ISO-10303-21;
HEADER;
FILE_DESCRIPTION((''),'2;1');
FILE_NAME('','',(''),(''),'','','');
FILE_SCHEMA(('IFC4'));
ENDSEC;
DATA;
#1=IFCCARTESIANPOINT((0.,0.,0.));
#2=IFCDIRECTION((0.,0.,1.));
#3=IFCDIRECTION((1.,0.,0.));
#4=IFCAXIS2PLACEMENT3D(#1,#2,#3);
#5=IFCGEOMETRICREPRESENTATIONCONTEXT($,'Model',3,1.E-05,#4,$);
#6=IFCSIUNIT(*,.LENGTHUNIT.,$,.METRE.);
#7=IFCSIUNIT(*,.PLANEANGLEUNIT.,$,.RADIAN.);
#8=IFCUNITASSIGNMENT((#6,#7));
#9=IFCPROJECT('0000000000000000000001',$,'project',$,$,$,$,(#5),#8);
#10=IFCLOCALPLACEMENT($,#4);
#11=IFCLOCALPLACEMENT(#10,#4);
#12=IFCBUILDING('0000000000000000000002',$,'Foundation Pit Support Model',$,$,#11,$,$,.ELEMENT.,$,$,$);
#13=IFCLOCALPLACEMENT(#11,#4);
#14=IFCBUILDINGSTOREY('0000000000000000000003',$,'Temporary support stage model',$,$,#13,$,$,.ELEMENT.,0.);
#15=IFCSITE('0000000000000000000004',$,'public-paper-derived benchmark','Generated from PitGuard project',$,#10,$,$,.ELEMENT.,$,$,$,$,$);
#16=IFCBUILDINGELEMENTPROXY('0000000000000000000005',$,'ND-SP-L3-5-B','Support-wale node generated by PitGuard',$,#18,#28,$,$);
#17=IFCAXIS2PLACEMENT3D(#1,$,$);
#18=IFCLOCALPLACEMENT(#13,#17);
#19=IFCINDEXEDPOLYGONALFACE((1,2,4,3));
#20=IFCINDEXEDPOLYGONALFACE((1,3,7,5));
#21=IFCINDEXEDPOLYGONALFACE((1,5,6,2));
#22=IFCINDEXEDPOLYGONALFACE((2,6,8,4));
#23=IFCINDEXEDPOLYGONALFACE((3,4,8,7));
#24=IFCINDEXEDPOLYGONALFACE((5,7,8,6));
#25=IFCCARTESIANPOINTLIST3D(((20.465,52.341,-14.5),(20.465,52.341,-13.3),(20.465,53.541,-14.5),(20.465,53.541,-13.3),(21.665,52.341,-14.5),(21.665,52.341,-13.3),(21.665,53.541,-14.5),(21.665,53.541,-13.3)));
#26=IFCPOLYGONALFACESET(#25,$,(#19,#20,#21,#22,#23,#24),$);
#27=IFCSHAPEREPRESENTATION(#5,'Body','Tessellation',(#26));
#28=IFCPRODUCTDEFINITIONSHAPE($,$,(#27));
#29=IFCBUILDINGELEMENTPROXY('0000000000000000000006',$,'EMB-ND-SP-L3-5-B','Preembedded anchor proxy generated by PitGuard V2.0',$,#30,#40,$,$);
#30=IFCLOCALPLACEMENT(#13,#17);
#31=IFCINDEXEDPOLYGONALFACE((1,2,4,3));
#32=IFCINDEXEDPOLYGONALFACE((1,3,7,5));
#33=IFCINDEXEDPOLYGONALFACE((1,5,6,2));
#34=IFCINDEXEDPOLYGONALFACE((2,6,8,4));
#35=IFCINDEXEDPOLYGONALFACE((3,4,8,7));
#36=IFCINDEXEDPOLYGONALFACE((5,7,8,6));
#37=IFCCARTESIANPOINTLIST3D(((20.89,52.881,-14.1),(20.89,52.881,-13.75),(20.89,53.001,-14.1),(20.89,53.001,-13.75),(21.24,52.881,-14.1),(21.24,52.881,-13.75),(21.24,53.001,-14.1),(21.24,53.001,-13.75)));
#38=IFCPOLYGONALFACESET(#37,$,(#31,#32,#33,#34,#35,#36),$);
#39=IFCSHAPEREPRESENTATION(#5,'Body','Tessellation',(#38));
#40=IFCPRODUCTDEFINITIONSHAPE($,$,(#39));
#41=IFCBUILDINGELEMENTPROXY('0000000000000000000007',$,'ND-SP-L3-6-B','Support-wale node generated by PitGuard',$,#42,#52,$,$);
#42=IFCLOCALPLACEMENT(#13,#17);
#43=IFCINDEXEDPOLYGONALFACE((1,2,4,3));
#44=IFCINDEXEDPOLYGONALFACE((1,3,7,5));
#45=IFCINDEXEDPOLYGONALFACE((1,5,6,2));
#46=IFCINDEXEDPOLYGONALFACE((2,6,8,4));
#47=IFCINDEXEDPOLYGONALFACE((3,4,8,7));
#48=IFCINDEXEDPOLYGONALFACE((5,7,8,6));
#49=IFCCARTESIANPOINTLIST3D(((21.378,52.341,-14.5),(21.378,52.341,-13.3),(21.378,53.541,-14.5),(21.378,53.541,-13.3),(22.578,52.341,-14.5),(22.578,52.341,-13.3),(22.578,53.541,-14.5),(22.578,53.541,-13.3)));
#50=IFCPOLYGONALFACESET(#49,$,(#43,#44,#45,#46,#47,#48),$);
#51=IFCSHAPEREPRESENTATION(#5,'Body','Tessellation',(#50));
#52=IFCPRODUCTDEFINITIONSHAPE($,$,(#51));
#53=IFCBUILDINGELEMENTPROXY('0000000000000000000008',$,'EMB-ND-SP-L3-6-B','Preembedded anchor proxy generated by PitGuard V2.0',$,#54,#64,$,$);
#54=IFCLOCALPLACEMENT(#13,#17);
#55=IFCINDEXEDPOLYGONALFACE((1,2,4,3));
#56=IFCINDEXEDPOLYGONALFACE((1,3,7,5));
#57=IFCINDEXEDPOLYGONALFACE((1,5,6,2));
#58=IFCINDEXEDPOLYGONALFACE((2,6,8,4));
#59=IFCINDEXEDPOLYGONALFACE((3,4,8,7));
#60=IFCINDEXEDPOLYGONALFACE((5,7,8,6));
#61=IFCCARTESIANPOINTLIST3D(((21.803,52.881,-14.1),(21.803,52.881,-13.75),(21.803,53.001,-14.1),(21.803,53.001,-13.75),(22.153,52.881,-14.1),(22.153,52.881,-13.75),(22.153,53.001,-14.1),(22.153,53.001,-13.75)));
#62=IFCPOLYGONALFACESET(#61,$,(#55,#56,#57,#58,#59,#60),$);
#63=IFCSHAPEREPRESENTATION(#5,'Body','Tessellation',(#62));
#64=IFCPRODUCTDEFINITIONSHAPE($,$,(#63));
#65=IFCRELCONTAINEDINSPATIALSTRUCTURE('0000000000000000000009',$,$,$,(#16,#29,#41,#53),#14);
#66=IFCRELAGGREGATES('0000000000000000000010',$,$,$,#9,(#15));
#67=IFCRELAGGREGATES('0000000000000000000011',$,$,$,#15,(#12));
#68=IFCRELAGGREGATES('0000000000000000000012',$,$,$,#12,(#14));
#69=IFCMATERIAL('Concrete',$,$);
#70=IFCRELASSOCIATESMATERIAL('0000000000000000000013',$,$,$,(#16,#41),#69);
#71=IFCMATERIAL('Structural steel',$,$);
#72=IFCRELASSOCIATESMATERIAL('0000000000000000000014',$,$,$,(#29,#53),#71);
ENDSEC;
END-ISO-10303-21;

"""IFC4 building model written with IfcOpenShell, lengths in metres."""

from ifc_helpers import new_model, si_unit, frame, origin_with_axes, origin_2d, place, context, project, spatial, rectangle, extrude, material, element, save


model = new_model("IFC4")

# Units and contexts
model_context = context("Model", 3, precision=1e-05, world=origin_with_axes())
ifc_project = project(units=[si_unit("LENGTHUNIT", "METRE"), si_unit("PLANEANGLEUNIT", "RADIAN")], contexts=[model_context])

# Site, building, storey
site_placement = place(None, origin_with_axes())
site = spatial("IfcSite", under=ifc_project, at=site_placement, Name="public-paper-derived benchmark", Description="Generated from PitGuard project", CompositionType="ELEMENT")
building_placement = place(site_placement, origin_with_axes())
building = spatial("IfcBuilding", under=site, at=building_placement, Name="Foundation Pit Support Model", CompositionType="ELEMENT")
storey_placement = place(building_placement, origin_with_axes())
storey = spatial("IfcBuildingStorey", under=building, at=storey_placement, Name="Temporary support stage model", CompositionType="ELEMENT", Elevation=0.0)

# Shared definitions
ifc_material_1 = material(Name="Structural steel")

# Building element proxies
ifc_material_2 = material(Name="Concrete")
proxy_1_placement = place(storey_placement, frame((21.065, 52.941, -14.5), z_axis=(0.0, 0.0, 1.0), x_axis=(1.0, 0.0, 0.0)))
element("IfcBuildingElementProxy", 1, at=proxy_1_placement, inside=storey, material=ifc_material_2, Name="ND-SP-L3-5-B", Description="Support-wale node generated by PitGuard", context=model_context, shape_type="SweptSolid", body=[
    extrude(rectangle(XDim=1.2, YDim=1.2, at=origin_2d()), origin_with_axes(), (0.0, 0.0, 1.0), 1.2),
])
proxy_2_placement = place(storey_placement, frame((21.065, 52.941, -14.1), z_axis=(0.0, 0.0, 1.0), x_axis=(1.0, 0.0, 0.0)))
element("IfcBuildingElementProxy", 2, at=proxy_2_placement, inside=storey, material=ifc_material_1, Name="EMB-ND-SP-L3-5-B", Description="Preembedded anchor proxy generated by PitGuard V2.0", context=model_context, shape_type="SweptSolid", body=[
    extrude(rectangle(XDim=0.35, YDim=0.12, at=origin_2d()), origin_with_axes(), (0.0, 0.0, 1.0), 0.35),
])
proxy_3_placement = place(storey_placement, frame((21.978, 52.941, -14.5), z_axis=(0.0, 0.0, 1.0), x_axis=(1.0, 0.0, 0.0)))
element("IfcBuildingElementProxy", 3, at=proxy_3_placement, inside=storey, material=ifc_material_2, Name="ND-SP-L3-6-B", Description="Support-wale node generated by PitGuard", context=model_context, shape_type="SweptSolid", body=[
    extrude(rectangle(XDim=1.2, YDim=1.2, at=origin_2d()), origin_with_axes(), (0.0, 0.0, 1.0), 1.2),
])
proxy_4_placement = place(storey_placement, frame((21.978, 52.941, -14.1), z_axis=(0.0, 0.0, 1.0), x_axis=(1.0, 0.0, 0.0)))
element("IfcBuildingElementProxy", 4, at=proxy_4_placement, inside=storey, material=ifc_material_1, Name="EMB-ND-SP-L3-6-B", Description="Preembedded anchor proxy generated by PitGuard V2.0", context=model_context, shape_type="SweptSolid", body=[
    extrude(rectangle(XDim=0.35, YDim=0.12, at=origin_2d()), origin_with_axes(), (0.0, 0.0, 1.0), 0.35),
])

save(model, "model.ifc")
